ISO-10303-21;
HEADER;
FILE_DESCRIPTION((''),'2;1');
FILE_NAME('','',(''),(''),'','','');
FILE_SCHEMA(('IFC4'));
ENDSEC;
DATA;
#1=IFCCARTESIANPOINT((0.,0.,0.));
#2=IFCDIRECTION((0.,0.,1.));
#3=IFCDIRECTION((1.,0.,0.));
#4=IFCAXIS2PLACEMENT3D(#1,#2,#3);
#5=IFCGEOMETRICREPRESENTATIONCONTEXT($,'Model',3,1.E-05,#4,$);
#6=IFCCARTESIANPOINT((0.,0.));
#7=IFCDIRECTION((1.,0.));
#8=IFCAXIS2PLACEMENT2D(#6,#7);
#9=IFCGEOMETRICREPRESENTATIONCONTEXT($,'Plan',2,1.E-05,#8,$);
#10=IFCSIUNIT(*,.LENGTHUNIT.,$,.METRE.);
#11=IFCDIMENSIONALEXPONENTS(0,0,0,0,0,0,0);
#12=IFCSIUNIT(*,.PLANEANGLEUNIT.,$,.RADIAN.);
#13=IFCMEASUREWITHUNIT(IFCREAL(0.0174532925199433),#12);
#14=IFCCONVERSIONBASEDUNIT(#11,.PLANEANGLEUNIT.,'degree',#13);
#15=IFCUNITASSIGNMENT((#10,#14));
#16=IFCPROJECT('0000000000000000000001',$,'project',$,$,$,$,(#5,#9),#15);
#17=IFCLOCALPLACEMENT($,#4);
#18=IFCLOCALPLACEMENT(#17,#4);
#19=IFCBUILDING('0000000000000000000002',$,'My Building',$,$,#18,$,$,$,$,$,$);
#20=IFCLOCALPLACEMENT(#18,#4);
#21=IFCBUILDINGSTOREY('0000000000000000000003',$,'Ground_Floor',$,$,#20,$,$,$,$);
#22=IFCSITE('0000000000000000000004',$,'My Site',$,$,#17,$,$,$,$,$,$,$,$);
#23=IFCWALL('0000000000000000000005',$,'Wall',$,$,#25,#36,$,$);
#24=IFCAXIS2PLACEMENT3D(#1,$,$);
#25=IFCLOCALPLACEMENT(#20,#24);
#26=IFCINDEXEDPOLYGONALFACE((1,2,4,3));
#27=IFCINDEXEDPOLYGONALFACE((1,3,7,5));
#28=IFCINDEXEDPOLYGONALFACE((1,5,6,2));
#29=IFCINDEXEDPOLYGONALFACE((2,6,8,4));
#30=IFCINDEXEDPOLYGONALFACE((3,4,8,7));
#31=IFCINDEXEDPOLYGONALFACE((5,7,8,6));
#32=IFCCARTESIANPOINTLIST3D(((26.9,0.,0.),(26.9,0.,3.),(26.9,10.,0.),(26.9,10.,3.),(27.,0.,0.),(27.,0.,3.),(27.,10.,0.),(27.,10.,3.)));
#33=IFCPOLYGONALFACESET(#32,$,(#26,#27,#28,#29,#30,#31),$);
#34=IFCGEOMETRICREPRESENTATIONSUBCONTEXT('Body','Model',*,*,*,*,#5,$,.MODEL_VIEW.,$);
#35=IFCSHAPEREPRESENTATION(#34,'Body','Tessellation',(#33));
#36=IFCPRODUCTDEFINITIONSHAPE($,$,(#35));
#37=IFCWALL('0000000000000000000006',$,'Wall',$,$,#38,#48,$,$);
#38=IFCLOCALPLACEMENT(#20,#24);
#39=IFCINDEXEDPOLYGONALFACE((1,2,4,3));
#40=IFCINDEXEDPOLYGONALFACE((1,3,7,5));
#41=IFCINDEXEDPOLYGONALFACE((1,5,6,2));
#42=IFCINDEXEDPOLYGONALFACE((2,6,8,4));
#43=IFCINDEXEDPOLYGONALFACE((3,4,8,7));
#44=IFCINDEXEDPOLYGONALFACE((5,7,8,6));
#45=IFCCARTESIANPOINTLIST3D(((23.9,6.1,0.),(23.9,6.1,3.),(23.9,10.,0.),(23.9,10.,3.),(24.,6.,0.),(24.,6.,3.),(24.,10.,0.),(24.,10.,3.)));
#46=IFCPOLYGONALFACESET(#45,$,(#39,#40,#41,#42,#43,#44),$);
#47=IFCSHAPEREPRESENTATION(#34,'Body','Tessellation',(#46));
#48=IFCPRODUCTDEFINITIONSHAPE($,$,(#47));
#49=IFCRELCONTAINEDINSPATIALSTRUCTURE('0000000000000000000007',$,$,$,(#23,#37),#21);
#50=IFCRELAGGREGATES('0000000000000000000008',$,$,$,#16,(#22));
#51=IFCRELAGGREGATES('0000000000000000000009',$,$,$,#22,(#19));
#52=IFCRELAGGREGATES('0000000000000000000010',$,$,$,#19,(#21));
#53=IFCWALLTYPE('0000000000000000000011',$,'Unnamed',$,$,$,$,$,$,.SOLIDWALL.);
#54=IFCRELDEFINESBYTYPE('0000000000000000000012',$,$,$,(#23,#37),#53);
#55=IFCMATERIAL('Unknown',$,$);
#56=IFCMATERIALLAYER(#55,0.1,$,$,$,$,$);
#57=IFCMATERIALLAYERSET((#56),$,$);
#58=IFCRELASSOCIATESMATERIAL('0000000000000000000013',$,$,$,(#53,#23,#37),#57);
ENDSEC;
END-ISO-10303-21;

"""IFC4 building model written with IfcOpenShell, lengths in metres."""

from ifc_helpers import new_model, entity, si_unit, converted_unit, frame, origin_with_axes, origin_2d_with_axis, place, context, subcontext, project, spatial, line, indexed_curve, outline, extrude, material, layer, layer_set, layer_usage, type_object, element, save


model = new_model("IFC4")

# Units and contexts
model_context = context("Model", 3, precision=1e-05, world=origin_with_axes())
plan_context = context("Plan", 2, precision=1e-05, world=origin_2d_with_axis())
body_context_1 = subcontext(model_context, "Body", "Model", "MODEL_VIEW")
ifc_project = project(units=[si_unit("LENGTHUNIT", "METRE"), converted_unit("PLANEANGLEUNIT", "degree", entity("IfcReal", 0.0174532925199433), si_unit("PLANEANGLEUNIT", "RADIAN"), dimensions=[0, 0, 0, 0, 0, 0, 0])], contexts=[model_context, plan_context])

# Site, building, storey
site_placement = place(None, origin_with_axes())
site = spatial("IfcSite", under=ifc_project, at=site_placement, Name="My Site")
building_placement = place(site_placement, origin_with_axes())
building = spatial("IfcBuilding", under=site, at=building_placement, Name="My Building")
storey_placement = place(building_placement, origin_with_axes())
storey = spatial("IfcBuildingStorey", under=building, at=storey_placement, Name="Ground_Floor")

# Walls
ifc_material = material(Name="Unknown")
ifc_layer = layer(ifc_material, 0.1)
ifc_layer_set = layer_set([ifc_layer])
ifc_layer_usage_1 = layer_usage(ifc_layer_set, "AXIS2", "POSITIVE", 0.0)
wall_type = type_object("IfcWallType", Name="Unnamed", PredefinedType="SOLIDWALL", material=ifc_layer_set)
wall_1_placement = place(storey_placement, frame((27.0, 0.0, 0.0), z_axis=(0.0, 0.0, 1.0), x_axis=(0.0, 1.0, 0.0)))
element("IfcWall", 1, at=wall_1_placement, inside=storey, type_object=wall_type, material=ifc_layer_usage_1, Name="Wall", context=body_context_1, shape_type="SweptSolid", body=[
    extrude(outline(indexed_curve([(0.0, 0.0), (0.0, 0.1), (10.0, 0.1), (10.0, 0.0)], segments=[line(1, 2, 3, 4, 1)])), origin_with_axes(), (0.0, 0.0, 1.0), 3.0),
])
ifc_layer_usage_2 = layer_usage(ifc_layer_set, "AXIS2", "POSITIVE", 0.0)
wall_2_placement = place(storey_placement, frame((24.0, 6.0, 0.0), z_axis=(0.0, 0.0, 1.0), x_axis=(0.0, 1.0, 0.0)))
element("IfcWall", 2, at=wall_2_placement, inside=storey, type_object=wall_type, material=ifc_layer_usage_2, Name="Wall", context=body_context_1, shape_type="SweptSolid", body=[
    extrude(outline(indexed_curve([(0.0, 0.0), (0.1, 0.1), (4.0, 0.1), (4.0, 0.0)], segments=[line(1, 2, 3, 4, 1)])), origin_with_axes(), (0.0, 0.0, 1.0), 3.0),
])

save(model, "model.ifc")
